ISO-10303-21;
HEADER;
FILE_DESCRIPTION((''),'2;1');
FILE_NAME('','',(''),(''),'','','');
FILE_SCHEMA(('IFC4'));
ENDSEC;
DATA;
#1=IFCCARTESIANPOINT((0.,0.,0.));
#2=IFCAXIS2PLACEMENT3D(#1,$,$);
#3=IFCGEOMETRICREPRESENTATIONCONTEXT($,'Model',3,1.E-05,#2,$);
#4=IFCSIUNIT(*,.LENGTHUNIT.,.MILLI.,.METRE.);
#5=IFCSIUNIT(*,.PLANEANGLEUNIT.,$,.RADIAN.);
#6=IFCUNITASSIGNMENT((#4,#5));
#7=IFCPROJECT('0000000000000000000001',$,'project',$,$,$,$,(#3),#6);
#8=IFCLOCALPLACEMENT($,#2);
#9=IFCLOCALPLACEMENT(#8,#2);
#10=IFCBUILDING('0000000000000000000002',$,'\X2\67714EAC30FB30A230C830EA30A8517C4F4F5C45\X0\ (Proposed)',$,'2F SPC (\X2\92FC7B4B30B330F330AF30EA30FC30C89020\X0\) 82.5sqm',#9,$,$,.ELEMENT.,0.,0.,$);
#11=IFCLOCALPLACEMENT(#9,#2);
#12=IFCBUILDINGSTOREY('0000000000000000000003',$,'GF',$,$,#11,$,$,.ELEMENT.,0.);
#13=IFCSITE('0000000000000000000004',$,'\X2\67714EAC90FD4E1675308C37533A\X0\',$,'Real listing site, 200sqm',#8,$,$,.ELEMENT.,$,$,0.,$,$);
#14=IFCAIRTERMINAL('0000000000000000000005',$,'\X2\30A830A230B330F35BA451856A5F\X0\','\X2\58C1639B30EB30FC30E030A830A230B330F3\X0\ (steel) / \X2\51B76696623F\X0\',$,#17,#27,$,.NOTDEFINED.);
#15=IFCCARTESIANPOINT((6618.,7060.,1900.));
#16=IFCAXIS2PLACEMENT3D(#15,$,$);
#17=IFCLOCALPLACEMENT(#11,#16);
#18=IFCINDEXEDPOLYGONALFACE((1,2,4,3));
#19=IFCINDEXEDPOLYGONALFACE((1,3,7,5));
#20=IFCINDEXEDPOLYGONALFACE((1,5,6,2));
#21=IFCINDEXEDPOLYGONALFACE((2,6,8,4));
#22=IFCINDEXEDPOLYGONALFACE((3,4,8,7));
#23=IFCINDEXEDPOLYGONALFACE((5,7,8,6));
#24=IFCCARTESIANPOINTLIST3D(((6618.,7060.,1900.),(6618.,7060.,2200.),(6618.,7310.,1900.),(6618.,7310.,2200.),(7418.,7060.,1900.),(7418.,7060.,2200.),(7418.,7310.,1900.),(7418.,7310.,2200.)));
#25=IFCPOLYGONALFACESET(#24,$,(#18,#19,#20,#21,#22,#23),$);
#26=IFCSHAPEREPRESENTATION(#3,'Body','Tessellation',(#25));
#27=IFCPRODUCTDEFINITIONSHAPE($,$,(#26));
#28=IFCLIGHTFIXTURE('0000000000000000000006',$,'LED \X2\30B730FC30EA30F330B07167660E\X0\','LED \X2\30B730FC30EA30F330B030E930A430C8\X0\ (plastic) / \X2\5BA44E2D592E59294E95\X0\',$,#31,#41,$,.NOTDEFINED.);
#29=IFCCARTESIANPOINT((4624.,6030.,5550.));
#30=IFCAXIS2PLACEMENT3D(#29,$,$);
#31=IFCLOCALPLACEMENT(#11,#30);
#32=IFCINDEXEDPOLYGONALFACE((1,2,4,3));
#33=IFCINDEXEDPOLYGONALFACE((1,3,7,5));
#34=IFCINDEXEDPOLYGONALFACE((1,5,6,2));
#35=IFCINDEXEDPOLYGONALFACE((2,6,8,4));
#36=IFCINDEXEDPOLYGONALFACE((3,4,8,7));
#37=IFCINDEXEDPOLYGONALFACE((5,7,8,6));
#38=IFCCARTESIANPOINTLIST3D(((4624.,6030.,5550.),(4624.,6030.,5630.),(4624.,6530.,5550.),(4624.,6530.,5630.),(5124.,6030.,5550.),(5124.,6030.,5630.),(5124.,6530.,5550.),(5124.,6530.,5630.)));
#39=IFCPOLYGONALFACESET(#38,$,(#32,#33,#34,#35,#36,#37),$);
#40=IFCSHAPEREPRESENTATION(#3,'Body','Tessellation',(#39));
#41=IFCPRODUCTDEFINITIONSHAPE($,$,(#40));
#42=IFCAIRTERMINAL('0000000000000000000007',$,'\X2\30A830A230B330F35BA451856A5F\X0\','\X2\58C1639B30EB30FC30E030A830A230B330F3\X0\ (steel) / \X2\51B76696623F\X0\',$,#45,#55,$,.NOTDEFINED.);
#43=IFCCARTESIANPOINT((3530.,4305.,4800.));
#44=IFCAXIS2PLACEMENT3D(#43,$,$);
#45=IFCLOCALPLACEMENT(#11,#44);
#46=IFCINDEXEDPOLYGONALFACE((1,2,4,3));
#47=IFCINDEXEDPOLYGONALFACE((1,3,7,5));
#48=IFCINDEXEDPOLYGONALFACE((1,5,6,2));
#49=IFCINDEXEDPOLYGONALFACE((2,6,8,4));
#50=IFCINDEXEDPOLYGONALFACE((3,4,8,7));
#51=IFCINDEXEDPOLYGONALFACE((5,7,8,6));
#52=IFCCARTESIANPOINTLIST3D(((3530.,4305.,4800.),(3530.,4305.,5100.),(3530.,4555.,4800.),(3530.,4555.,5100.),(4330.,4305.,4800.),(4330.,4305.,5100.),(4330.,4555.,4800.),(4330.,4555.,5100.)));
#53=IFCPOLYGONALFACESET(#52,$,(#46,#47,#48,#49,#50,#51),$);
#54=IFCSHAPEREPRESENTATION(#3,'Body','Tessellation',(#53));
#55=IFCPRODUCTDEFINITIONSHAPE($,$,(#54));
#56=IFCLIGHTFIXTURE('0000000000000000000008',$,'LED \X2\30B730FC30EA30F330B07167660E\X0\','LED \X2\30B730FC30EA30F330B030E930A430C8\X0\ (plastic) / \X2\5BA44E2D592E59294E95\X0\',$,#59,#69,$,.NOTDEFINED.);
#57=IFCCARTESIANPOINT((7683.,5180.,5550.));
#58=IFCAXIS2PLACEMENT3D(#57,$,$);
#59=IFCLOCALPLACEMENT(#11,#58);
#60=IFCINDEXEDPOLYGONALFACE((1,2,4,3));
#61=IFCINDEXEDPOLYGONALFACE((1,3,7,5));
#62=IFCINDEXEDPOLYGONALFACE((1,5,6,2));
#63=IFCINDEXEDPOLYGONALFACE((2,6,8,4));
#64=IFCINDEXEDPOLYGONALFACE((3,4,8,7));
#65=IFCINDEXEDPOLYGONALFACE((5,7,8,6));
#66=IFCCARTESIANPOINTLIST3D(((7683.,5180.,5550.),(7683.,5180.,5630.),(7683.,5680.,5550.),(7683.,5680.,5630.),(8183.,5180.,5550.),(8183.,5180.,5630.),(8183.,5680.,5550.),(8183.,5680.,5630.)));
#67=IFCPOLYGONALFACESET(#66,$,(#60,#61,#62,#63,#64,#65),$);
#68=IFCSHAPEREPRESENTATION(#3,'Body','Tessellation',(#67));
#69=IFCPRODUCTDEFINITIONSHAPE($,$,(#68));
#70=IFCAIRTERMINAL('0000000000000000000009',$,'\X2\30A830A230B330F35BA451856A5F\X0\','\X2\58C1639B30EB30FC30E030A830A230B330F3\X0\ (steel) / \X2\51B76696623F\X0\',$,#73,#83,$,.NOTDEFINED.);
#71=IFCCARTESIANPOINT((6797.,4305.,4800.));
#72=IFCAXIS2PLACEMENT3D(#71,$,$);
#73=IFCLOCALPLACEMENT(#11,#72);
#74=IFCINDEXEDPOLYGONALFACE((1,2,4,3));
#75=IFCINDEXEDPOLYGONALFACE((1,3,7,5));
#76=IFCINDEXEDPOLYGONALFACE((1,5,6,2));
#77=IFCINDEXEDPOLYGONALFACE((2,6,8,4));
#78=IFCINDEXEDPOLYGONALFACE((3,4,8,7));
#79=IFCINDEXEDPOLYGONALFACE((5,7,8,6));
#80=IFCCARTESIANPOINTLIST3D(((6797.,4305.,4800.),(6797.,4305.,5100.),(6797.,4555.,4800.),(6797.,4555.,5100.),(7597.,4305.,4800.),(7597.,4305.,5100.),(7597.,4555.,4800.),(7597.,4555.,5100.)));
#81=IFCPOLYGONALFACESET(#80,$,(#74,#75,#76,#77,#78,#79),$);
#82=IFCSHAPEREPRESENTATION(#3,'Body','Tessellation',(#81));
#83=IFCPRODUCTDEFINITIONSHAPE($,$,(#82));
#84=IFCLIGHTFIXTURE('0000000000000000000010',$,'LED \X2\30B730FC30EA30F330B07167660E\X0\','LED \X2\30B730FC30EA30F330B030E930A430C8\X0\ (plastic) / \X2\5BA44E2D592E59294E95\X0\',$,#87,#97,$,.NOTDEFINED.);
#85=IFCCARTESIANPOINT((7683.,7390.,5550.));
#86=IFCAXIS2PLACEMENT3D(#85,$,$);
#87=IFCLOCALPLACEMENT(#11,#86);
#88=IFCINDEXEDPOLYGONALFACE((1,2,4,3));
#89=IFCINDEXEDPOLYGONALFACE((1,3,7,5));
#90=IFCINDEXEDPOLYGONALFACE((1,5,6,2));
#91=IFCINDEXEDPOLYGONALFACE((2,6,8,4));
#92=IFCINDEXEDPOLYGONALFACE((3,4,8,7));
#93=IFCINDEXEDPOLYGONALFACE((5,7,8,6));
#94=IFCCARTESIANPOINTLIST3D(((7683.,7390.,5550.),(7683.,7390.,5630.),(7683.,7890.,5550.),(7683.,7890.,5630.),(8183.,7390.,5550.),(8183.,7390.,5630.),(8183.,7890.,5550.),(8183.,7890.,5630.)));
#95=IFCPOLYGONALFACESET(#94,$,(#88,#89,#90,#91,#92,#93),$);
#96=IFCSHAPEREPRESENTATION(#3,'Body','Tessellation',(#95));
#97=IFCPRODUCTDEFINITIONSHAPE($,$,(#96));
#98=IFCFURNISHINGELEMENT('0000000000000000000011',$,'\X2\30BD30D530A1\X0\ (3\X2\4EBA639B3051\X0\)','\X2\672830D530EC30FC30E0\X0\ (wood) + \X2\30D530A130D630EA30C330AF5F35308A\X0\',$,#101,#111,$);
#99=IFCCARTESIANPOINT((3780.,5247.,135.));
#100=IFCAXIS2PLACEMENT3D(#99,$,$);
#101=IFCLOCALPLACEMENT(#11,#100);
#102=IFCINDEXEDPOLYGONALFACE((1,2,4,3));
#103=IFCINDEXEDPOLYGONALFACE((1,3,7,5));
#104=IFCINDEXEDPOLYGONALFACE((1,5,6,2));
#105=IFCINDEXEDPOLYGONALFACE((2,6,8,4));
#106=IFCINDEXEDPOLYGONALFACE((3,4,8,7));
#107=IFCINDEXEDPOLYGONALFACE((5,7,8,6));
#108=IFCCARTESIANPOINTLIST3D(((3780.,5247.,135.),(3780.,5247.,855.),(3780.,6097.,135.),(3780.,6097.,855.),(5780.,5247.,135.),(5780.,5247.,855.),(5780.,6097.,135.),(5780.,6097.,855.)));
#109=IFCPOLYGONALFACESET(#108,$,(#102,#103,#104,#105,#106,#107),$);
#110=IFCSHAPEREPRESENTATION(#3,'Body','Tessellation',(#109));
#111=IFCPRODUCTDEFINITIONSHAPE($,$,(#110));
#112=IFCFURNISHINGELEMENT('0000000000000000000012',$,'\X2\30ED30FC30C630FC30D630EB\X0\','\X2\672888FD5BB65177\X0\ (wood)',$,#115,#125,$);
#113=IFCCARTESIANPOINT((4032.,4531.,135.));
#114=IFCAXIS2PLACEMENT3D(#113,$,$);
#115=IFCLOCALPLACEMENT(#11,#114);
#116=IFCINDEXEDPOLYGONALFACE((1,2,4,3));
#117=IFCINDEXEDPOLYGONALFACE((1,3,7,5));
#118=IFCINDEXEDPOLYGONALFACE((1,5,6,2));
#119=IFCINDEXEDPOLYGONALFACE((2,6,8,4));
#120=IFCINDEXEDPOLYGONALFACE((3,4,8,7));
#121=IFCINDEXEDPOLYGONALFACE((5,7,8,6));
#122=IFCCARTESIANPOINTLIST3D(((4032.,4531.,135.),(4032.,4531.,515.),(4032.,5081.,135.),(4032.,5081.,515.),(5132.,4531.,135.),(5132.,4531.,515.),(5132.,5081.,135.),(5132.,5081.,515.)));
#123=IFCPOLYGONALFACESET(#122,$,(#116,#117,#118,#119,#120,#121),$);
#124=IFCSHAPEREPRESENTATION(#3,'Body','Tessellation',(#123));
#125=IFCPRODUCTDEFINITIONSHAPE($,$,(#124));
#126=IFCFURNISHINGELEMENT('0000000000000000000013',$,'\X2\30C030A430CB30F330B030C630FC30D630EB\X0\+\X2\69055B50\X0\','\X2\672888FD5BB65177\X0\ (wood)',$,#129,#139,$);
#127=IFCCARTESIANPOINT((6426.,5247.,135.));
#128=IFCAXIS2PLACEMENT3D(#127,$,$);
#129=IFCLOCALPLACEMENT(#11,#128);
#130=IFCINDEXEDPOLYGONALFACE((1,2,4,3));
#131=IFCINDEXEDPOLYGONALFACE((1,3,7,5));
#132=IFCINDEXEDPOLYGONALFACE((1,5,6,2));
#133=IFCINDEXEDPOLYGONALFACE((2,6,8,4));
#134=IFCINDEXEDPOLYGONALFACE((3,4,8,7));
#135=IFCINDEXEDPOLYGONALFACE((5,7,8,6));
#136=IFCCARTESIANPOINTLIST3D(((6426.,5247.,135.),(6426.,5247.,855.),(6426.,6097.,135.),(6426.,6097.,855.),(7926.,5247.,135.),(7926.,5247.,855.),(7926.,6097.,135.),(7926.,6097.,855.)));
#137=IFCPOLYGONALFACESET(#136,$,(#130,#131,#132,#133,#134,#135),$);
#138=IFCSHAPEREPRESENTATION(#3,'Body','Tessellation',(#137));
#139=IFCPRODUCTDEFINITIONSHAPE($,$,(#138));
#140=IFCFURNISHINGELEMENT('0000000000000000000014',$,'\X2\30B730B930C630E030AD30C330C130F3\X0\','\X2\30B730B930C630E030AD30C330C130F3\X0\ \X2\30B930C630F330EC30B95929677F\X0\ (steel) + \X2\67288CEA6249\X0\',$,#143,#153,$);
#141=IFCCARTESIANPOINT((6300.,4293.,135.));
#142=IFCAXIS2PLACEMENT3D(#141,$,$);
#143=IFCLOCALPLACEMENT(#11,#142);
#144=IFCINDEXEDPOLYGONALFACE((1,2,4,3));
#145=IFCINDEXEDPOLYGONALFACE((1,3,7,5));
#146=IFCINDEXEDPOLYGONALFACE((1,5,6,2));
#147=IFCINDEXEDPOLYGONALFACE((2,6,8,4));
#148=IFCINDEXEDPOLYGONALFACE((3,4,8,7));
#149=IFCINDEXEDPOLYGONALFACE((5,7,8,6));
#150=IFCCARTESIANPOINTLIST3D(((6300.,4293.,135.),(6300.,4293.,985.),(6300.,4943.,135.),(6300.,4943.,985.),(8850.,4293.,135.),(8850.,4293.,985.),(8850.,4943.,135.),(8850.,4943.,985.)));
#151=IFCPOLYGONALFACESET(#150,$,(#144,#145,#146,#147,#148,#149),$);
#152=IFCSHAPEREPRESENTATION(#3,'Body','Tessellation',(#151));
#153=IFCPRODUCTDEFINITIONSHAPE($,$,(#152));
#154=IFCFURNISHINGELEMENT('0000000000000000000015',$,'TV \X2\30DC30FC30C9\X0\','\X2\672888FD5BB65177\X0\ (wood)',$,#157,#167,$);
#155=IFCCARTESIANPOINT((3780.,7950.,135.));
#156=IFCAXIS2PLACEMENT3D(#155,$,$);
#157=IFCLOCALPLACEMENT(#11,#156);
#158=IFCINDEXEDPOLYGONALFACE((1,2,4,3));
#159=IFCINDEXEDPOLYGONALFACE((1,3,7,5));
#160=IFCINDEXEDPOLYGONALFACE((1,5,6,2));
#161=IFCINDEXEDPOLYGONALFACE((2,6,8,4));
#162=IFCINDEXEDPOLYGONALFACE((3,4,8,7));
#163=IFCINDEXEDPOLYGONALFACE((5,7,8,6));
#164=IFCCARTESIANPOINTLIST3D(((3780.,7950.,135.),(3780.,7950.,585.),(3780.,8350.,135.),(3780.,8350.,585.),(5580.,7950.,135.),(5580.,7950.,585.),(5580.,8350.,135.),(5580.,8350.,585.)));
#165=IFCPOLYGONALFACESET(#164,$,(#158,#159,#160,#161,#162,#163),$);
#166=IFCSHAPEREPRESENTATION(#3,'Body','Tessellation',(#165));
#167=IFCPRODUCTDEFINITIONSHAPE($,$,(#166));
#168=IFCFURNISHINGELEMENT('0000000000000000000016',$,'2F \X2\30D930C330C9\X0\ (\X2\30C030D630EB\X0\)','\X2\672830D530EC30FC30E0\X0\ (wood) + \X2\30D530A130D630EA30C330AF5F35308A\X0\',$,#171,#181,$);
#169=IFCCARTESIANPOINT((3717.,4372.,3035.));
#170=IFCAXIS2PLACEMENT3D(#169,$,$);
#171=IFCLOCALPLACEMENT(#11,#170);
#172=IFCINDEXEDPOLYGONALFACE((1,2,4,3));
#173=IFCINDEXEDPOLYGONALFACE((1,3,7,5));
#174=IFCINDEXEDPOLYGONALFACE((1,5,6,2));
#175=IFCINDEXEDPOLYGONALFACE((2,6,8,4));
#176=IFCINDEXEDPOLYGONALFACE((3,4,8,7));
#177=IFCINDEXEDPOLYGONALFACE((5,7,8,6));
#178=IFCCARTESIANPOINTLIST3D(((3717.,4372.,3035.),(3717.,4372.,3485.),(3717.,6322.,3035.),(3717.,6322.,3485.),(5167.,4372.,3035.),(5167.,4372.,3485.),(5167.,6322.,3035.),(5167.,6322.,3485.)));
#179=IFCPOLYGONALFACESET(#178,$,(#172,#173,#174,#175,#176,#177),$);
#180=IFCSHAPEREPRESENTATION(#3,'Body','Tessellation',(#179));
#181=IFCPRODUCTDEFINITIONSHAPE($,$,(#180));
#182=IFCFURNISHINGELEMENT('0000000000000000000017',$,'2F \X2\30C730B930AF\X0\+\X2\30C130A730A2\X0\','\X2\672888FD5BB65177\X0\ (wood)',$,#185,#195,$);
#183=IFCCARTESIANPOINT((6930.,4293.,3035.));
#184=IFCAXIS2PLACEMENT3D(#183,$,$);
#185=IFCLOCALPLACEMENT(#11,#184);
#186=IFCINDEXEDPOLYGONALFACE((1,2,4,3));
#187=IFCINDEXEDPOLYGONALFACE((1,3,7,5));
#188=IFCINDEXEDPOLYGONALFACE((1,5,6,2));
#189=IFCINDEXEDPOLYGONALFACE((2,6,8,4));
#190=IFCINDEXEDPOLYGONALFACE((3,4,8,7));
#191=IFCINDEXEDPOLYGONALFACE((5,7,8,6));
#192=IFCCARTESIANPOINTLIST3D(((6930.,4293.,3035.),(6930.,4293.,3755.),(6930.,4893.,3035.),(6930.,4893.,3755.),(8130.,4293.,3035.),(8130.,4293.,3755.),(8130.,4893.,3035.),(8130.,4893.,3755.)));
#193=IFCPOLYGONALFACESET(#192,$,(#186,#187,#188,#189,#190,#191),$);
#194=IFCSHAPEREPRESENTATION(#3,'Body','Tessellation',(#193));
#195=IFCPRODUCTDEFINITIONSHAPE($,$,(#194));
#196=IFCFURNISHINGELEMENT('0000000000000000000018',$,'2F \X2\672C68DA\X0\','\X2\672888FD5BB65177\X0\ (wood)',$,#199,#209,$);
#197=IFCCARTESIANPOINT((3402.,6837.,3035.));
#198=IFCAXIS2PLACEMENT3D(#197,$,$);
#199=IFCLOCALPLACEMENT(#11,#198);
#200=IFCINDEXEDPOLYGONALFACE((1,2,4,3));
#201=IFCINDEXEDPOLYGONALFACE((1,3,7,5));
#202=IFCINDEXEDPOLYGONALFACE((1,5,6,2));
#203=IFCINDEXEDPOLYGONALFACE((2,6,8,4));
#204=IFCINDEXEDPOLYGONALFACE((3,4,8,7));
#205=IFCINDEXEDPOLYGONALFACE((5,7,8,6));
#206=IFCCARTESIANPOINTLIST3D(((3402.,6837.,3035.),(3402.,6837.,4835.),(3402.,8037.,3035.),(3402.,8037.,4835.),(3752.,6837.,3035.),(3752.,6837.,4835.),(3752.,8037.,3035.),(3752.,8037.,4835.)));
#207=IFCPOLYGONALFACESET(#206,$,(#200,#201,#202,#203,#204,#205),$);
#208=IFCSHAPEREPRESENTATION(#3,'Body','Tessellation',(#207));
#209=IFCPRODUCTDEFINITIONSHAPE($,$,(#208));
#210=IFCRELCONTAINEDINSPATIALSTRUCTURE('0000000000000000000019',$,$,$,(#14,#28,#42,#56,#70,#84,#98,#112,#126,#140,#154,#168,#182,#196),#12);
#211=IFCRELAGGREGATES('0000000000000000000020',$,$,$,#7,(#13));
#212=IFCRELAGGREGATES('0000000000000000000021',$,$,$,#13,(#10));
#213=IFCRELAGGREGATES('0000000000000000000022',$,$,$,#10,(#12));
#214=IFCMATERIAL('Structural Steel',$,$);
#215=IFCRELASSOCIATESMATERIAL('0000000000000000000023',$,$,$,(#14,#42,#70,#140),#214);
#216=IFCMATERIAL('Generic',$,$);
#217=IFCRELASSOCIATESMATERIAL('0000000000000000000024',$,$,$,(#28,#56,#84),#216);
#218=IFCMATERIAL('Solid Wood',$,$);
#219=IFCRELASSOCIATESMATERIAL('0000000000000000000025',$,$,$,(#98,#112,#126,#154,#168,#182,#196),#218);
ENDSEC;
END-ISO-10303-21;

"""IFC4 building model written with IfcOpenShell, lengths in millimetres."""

from ifc_helpers import new_model, si_unit, frame, frame_2d, origin, place, context, project, spatial, rectangle, extrude, material, element, save


model = new_model("IFC4")

# Units and contexts
model_context = context("Model", 3, precision=1e-05, world=origin())
ifc_project = project(units=[si_unit("LENGTHUNIT", "METRE", prefix="MILLI"), si_unit("PLANEANGLEUNIT", "RADIAN")], contexts=[model_context])

# Site, building, storey
site_placement = place(None, origin())
site = spatial("IfcSite", under=ifc_project, at=site_placement, Name="東京都世田谷区", ObjectType="Real listing site, 200sqm", CompositionType="ELEMENT", RefElevation=0.0)
building_placement = place(site_placement, origin())
building = spatial("IfcBuilding", under=site, at=building_placement, Name="東京・アトリエ兼住居 (Proposed)", ObjectType="2F SPC (鋼筋コンクリート造) 82.5sqm", CompositionType="ELEMENT", ElevationOfRefHeight=0.0, ElevationOfTerrain=0.0)
storey_placement = place(building_placement, origin())
storey = spatial("IfcBuildingStorey", under=building, at=storey_placement, Name="GF", CompositionType="ELEMENT", Elevation=0.0)

# Shared definitions
ifc_material_1 = material(Name="Solid Wood")

# Shared definitions
ifc_material_2 = material(Name="Structural Steel")

# Shared definitions
ifc_material_3 = material(Name="Generic")

# Air terminal
air_terminal_1_placement = place(storey_placement, frame((6618.0, 7060.0, 1900.0)))
element("IfcAirTerminal", 1, at=air_terminal_1_placement, inside=storey, material=ifc_material_2, Name="エアコン室内機", Description="壁掛ルームエアコン (steel) / 冷暖房", PredefinedType="NOTDEFINED", context=model_context, shape_type="SweptSolid", body=[
    extrude(rectangle(XDim=800.0, YDim=250.0, at=frame_2d((400.0, 125.0))), frame((6618.0, 7060.0, 1900.0)), (0.0, 0.0, 1.0), 300.0),
])

# Light fixture
light_fixture_1_placement = place(storey_placement, frame((4624.0, 6030.0, 5550.0)))
element("IfcLightFixture", 2, at=light_fixture_1_placement, inside=storey, material=ifc_material_3, Name="LED シーリング照明", Description="LED シーリングライト (plastic) / 室中央天井", PredefinedType="NOTDEFINED", context=model_context, shape_type="SweptSolid", body=[
    extrude(rectangle(XDim=500.0, YDim=500.0, at=frame_2d((250.0, 250.0))), frame((4624.0, 6030.0, 5550.0)), (0.0, 0.0, 1.0), 80.0),
])

# Air terminal
air_terminal_2_placement = place(storey_placement, frame((3530.0, 4305.0, 4800.0)))
element("IfcAirTerminal", 3, at=air_terminal_2_placement, inside=storey, material=ifc_material_2, Name="エアコン室内機", Description="壁掛ルームエアコン (steel) / 冷暖房", PredefinedType="NOTDEFINED", context=model_context, shape_type="SweptSolid", body=[
    extrude(rectangle(XDim=800.0, YDim=250.0, at=frame_2d((400.0, 125.0))), frame((3530.0, 4305.0, 4800.0)), (0.0, 0.0, 1.0), 300.0),
])

# Light fixture
light_fixture_2_placement = place(storey_placement, frame((7683.0, 5180.0, 5550.0)))
element("IfcLightFixture", 4, at=light_fixture_2_placement, inside=storey, material=ifc_material_3, Name="LED シーリング照明", Description="LED シーリングライト (plastic) / 室中央天井", PredefinedType="NOTDEFINED", context=model_context, shape_type="SweptSolid", body=[
    extrude(rectangle(XDim=500.0, YDim=500.0, at=frame_2d((250.0, 250.0))), frame((7683.0, 5180.0, 5550.0)), (0.0, 0.0, 1.0), 80.0),
])

# Air terminal
air_terminal_3_placement = place(storey_placement, frame((6797.0, 4305.0, 4800.0)))
element("IfcAirTerminal", 5, at=air_terminal_3_placement, inside=storey, material=ifc_material_2, Name="エアコン室内機", Description="壁掛ルームエアコン (steel) / 冷暖房", PredefinedType="NOTDEFINED", context=model_context, shape_type="SweptSolid", body=[
    extrude(rectangle(XDim=800.0, YDim=250.0, at=frame_2d((400.0, 125.0))), frame((6797.0, 4305.0, 4800.0)), (0.0, 0.0, 1.0), 300.0),
])

# Light fixture
light_fixture_3_placement = place(storey_placement, frame((7683.0, 7390.0, 5550.0)))
element("IfcLightFixture", 6, at=light_fixture_3_placement, inside=storey, material=ifc_material_3, Name="LED シーリング照明", Description="LED シーリングライト (plastic) / 室中央天井", PredefinedType="NOTDEFINED", context=model_context, shape_type="SweptSolid", body=[
    extrude(rectangle(XDim=500.0, YDim=500.0, at=frame_2d((250.0, 250.0))), frame((7683.0, 7390.0, 5550.0)), (0.0, 0.0, 1.0), 80.0),
])

# Furnishing elements
furnishing_1_placement = place(storey_placement, frame((3780.0, 5247.0, 135.0)))
element("IfcFurnishingElement", 7, at=furnishing_1_placement, inside=storey, material=ifc_material_1, Name="ソファ (3人掛け)", Description="木フレーム (wood) + ファブリック張り", context=model_context, shape_type="SweptSolid", body=[
    extrude(rectangle(XDim=2000.0, YDim=850.0, at=frame_2d((1000.0, 425.0))), frame((3780.0, 5247.0, 135.0)), (0.0, 0.0, 1.0), 720.0),
])
furnishing_2_placement = place(storey_placement, frame((4032.0, 4531.0, 135.0)))
element("IfcFurnishingElement", 8, at=furnishing_2_placement, inside=storey, material=ifc_material_1, Name="ローテーブル", Description="木製家具 (wood)", context=model_context, shape_type="SweptSolid", body=[
    extrude(rectangle(XDim=1100.0, YDim=550.0, at=frame_2d((550.0, 275.0))), frame((4032.0, 4531.0, 135.0)), (0.0, 0.0, 1.0), 380.0),
])
furnishing_3_placement = place(storey_placement, frame((6426.0, 5247.0, 135.0)))
element("IfcFurnishingElement", 9, at=furnishing_3_placement, inside=storey, material=ifc_material_1, Name="ダイニングテーブル+椅子", Description="木製家具 (wood)", context=model_context, shape_type="SweptSolid", body=[
    extrude(rectangle(XDim=1500.0, YDim=850.0, at=frame_2d((750.0, 425.0))), frame((6426.0, 5247.0, 135.0)), (0.0, 0.0, 1.0), 720.0),
])
furnishing_4_placement = place(storey_placement, frame((6300.0, 4293.0, 135.0)))
element("IfcFurnishingElement", 10, at=furnishing_4_placement, inside=storey, material=ifc_material_2, Name="システムキッチン", Description="システムキッチン ステンレス天板 (steel) + 木質扉", context=model_context, shape_type="SweptSolid", body=[
    extrude(rectangle(XDim=2550.0, YDim=650.0, at=frame_2d((1275.0, 325.0))), frame((6300.0, 4293.0, 135.0)), (0.0, 0.0, 1.0), 850.0),
])
furnishing_5_placement = place(storey_placement, frame((3780.0, 7950.0, 135.0)))
element("IfcFurnishingElement", 11, at=furnishing_5_placement, inside=storey, material=ifc_material_1, Name="TV ボード", Description="木製家具 (wood)", context=model_context, shape_type="SweptSolid", body=[
    extrude(rectangle(XDim=1800.0, YDim=400.0, at=frame_2d((900.0, 200.0))), frame((3780.0, 7950.0, 135.0)), (0.0, 0.0, 1.0), 450.0),
])
furnishing_6_placement = place(storey_placement, frame((3717.0, 4372.0, 3035.0)))
element("IfcFurnishingElement", 12, at=furnishing_6_placement, inside=storey, material=ifc_material_1, Name="2F ベッド (ダブル)", Description="木フレーム (wood) + ファブリック張り", context=model_context, shape_type="SweptSolid", body=[
    extrude(rectangle(XDim=1450.0, YDim=1950.0, at=frame_2d((725.0, 975.0))), frame((3717.0, 4372.0, 3035.0)), (0.0, 0.0, 1.0), 450.0),
])
furnishing_7_placement = place(storey_placement, frame((6930.0, 4293.0, 3035.0)))
element("IfcFurnishingElement", 13, at=furnishing_7_placement, inside=storey, material=ifc_material_1, Name="2F デスク+チェア", Description="木製家具 (wood)", context=model_context, shape_type="SweptSolid", body=[
    extrude(rectangle(XDim=1200.0, YDim=600.0, at=frame_2d((600.0, 300.0))), frame((6930.0, 4293.0, 3035.0)), (0.0, 0.0, 1.0), 720.0),
])
furnishing_8_placement = place(storey_placement, frame((3402.0, 6837.0, 3035.0)))
element("IfcFurnishingElement", 14, at=furnishing_8_placement, inside=storey, material=ifc_material_1, Name="2F 本棚", Description="木製家具 (wood)", context=model_context, shape_type="SweptSolid", body=[
    extrude(rectangle(XDim=350.0, YDim=1200.0, at=frame_2d((175.0, 600.0))), frame((3402.0, 6837.0, 3035.0)), (0.0, 0.0, 1.0), 1800.0),
])

save(model, "model.ifc")
